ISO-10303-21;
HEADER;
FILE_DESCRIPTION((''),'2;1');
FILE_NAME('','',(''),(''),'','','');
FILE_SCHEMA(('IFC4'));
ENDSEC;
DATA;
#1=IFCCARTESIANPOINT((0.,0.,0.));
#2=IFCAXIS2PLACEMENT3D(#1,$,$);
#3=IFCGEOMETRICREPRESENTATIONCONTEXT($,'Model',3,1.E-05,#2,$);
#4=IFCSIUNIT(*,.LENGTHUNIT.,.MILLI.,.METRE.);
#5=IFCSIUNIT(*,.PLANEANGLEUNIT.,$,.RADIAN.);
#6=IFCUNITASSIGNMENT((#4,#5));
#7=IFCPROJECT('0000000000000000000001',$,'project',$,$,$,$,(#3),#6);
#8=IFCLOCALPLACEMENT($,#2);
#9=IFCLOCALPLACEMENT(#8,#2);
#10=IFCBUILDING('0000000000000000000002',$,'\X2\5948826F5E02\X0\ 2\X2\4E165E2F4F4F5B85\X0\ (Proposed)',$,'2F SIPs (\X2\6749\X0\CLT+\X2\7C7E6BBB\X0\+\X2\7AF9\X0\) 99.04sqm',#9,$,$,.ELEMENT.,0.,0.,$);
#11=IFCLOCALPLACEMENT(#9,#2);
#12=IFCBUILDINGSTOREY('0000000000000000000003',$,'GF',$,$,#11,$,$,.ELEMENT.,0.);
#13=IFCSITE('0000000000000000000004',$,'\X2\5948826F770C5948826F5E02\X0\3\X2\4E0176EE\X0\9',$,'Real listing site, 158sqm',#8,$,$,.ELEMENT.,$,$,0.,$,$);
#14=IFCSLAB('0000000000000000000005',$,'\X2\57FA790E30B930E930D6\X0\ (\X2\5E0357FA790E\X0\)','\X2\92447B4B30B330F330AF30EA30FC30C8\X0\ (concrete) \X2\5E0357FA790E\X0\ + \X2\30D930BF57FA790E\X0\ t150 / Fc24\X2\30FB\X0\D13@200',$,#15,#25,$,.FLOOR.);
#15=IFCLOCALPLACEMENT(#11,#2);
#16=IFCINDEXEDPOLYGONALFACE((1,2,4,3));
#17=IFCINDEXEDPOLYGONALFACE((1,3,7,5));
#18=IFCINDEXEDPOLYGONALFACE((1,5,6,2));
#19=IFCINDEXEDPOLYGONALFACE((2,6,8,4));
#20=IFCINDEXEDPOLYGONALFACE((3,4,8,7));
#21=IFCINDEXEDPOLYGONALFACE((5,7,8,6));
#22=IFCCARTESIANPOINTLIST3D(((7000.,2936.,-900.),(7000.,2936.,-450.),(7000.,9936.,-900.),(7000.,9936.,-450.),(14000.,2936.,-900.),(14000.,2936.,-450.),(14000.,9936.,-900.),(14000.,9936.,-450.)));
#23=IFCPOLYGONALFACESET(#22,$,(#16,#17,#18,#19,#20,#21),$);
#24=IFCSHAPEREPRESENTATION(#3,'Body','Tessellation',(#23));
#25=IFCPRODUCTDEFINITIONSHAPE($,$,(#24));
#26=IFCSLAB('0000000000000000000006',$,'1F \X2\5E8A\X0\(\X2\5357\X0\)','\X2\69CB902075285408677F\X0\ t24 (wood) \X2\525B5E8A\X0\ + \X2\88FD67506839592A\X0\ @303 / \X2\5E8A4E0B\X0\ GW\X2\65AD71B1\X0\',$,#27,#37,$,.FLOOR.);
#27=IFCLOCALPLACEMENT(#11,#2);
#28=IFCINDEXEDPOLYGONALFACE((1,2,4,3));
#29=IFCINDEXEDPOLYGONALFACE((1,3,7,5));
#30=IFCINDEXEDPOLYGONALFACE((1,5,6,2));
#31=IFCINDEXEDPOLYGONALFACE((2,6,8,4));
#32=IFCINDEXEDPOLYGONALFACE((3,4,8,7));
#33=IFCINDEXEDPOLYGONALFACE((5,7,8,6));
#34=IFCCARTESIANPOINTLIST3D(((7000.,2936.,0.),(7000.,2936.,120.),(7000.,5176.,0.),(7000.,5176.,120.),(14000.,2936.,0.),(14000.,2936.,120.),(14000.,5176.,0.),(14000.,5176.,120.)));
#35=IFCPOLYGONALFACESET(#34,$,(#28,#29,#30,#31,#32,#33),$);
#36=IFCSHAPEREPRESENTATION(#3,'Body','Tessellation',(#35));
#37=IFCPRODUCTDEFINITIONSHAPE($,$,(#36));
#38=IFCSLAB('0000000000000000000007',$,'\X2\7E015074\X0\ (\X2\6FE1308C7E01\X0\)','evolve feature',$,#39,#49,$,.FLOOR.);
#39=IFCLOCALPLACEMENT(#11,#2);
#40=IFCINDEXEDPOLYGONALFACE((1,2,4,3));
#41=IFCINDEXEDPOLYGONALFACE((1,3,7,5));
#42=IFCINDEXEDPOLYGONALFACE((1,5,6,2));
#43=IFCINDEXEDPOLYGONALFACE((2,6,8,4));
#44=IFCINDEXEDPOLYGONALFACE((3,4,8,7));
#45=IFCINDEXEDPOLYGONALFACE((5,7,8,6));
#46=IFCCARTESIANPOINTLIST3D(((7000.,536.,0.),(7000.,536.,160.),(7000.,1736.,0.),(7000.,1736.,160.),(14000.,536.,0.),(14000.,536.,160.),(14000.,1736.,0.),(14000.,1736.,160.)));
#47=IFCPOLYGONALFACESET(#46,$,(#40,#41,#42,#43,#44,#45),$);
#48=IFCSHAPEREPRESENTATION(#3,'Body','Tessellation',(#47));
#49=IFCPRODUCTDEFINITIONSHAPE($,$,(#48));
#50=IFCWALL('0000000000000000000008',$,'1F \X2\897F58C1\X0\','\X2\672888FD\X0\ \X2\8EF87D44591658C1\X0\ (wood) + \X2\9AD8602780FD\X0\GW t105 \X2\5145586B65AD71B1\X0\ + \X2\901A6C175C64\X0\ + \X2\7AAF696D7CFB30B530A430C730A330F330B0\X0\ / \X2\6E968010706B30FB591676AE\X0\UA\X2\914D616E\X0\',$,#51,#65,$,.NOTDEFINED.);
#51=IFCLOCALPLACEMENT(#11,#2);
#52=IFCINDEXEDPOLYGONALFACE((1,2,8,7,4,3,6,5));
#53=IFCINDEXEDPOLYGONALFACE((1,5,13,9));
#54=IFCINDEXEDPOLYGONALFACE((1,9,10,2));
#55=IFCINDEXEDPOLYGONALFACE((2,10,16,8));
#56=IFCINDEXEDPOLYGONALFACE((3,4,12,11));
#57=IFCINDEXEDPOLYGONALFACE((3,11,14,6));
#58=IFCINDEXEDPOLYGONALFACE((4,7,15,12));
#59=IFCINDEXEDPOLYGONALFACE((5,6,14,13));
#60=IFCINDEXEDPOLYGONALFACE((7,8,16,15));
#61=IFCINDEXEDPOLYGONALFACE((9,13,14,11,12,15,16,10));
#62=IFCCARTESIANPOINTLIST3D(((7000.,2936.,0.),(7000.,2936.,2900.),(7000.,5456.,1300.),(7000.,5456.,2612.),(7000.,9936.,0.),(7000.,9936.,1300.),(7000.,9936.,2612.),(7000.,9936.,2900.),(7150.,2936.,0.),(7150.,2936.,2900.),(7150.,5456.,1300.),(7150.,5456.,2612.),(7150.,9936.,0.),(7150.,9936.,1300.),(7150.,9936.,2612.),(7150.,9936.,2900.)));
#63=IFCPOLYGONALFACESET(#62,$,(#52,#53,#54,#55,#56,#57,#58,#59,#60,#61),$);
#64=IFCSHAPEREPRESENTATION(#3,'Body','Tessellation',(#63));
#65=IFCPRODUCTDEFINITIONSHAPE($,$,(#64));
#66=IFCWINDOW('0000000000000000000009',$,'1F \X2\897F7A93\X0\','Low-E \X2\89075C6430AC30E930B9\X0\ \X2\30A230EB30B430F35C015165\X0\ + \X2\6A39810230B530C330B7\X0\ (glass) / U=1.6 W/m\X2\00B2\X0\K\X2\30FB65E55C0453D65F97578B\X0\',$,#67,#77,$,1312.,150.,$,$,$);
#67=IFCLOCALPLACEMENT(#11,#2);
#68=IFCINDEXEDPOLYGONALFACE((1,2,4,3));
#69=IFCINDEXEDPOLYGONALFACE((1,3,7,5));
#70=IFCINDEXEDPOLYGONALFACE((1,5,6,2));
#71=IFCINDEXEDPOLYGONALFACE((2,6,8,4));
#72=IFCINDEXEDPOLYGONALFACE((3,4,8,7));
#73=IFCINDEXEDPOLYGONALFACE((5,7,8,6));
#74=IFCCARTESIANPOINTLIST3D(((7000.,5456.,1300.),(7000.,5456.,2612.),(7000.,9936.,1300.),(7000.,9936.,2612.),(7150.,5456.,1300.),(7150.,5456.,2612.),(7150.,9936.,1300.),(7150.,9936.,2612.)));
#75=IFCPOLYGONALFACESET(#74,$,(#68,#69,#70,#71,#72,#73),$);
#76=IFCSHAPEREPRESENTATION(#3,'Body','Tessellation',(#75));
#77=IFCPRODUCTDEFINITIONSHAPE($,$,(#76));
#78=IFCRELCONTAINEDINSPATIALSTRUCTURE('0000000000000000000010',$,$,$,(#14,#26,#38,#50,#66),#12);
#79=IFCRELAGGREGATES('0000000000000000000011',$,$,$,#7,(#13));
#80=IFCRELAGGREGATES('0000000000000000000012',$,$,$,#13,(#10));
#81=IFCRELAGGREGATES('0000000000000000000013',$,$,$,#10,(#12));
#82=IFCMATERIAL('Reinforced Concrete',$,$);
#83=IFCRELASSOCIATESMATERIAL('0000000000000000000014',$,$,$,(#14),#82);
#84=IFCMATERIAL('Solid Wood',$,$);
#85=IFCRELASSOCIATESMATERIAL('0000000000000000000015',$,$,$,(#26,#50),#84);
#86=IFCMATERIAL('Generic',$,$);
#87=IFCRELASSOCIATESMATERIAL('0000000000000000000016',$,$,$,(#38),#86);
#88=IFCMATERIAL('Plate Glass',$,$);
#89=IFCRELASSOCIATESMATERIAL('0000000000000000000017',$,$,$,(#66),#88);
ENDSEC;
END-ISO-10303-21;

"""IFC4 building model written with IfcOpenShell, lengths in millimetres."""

from ifc_helpers import new_model, si_unit, frame, frame_2d, origin, place, context, project, spatial, rectangle, extrude, material, element, fill, save


model = new_model("IFC4")

# Units and contexts
model_context = context("Model", 3, precision=1e-05, world=origin())
ifc_project = project(units=[si_unit("LENGTHUNIT", "METRE", prefix="MILLI"), si_unit("PLANEANGLEUNIT", "RADIAN")], contexts=[model_context])

# Site, building, storey
site_placement = place(None, origin())
site = spatial("IfcSite", under=ifc_project, at=site_placement, Name="奈良県奈良市3丁目9", ObjectType="Real listing site, 158sqm", CompositionType="ELEMENT", RefElevation=0.0)
building_placement = place(site_placement, origin())
building = spatial("IfcBuilding", under=site, at=building_placement, Name="奈良市 2世帯住宅 (Proposed)", ObjectType="2F SIPs (杉CLT+籾殻+竹) 99.04sqm", CompositionType="ELEMENT", ElevationOfRefHeight=0.0, ElevationOfTerrain=0.0)
storey_placement = place(building_placement, origin())
storey = spatial("IfcBuildingStorey", under=building, at=storey_placement, Name="GF", CompositionType="ELEMENT", Elevation=0.0)

# Slabs
ifc_material_1 = material(Name="Reinforced Concrete")
slab_1_placement = place(storey_placement, frame((3500.0, 1468.0, -450.0)))
element("IfcSlab", 1, at=slab_1_placement, inside=storey, material=ifc_material_1, Name="基礎スラブ (布基礎)", Description="鉄筋コンクリート (concrete) 布基礎 + ベタ基礎 t150 / Fc24・D13@200", PredefinedType="FLOOR", context=model_context, shape_type="SweptSolid", body=[
    extrude(rectangle(XDim=7000.0, YDim=7000.0, at=frame_2d((3500.0, 3500.0))), frame((3500.0, 1468.0, -450.0)), (0.0, 0.0, 1.0), 450.0),
])
ifc_material_2 = material(Name="Solid Wood")
slab_2_placement = place(storey_placement, frame((3500.0, 1468.0, 0.0)))
element("IfcSlab", 2, at=slab_2_placement, inside=storey, material=ifc_material_2, Name="1F 床(南)", Description="構造用合板 t24 (wood) 剛床 + 製材根太 @303 / 床下 GW断熱", PredefinedType="FLOOR", context=model_context, shape_type="SweptSolid", body=[
    extrude(rectangle(XDim=7000.0, YDim=2240.0, at=frame_2d((3500.0, 1120.0))), frame((3500.0, 1468.0, 0.0)), (0.0, 0.0, 1.0), 120.0),
])
ifc_material_3 = material(Name="Generic")
slab_3_placement = place(storey_placement, frame((3500.0, 268.0, 0.0)))
element("IfcSlab", 3, at=slab_3_placement, inside=storey, material=ifc_material_3, Name="縁側 (濡れ縁)", Description="evolve feature", PredefinedType="FLOOR", context=model_context, shape_type="SweptSolid", body=[
    extrude(rectangle(XDim=7000.0, YDim=1200.0, at=frame_2d((3500.0, 600.0))), frame((3500.0, 268.0, 0.0)), (0.0, 0.0, 1.0), 160.0),
])

# Shared definitions
ifc_material_4 = material(Name="Plate Glass")

# Wall, opening, window
wall_1_placement = place(storey_placement, frame((3500.0, 1468.0, 0.0)))
wall_1 = element("IfcWall", 4, at=wall_1_placement, inside=storey, material=ifc_material_2, Name="1F 西壁", Description="木製 軸組外壁 (wood) + 高性能GW t105 充填断熱 + 通気層 + 窯業系サイディング / 準耐火・外皮UA配慮", PredefinedType="NOTDEFINED", context=model_context, shape_type="SweptSolid", body=[
    extrude(rectangle(XDim=150.0, YDim=7000.0, at=frame_2d((75.0, 3500.0))), frame((3500.0, 1468.0, 0.0)), (0.0, 0.0, 1.0), 2900.0),
])
opening_1_placement = place(storey_placement, frame((3500.0, 2728.0, 650.0)))
opening_1 = element("IfcOpeningElement", 5, at=opening_1_placement, cuts=wall_1, PredefinedType="NOTDEFINED", context=model_context, shape_type="SweptSolid", body=[
    extrude(rectangle(XDim=150.0, YDim=4480.0, at=frame_2d((75.0, 2240.0))), frame((3500.0, 2728.0, 650.0)), (0.0, 0.0, 1.0), 1312.0),
])
window_1_placement = place(storey_placement, frame((3500.0, 2728.0, 650.0)))
window_1 = element("IfcWindow", 6, at=window_1_placement, inside=storey, material=ifc_material_4, Name="1F 西窓", Description="Low-E 複層ガラス アルゴン封入 + 樹脂サッシ (glass) / U=1.6 W/m²K・日射取得型", OverallHeight=1312.0, OverallWidth=150.0, context=model_context, shape_type="SweptSolid", body=[
    extrude(rectangle(XDim=150.0, YDim=4480.0, at=frame_2d((75.0, 2240.0))), frame((3500.0, 2728.0, 650.0)), (0.0, 0.0, 1.0), 1312.0),
])
fill(opening_1, window_1)

save(model, "model.ifc")
